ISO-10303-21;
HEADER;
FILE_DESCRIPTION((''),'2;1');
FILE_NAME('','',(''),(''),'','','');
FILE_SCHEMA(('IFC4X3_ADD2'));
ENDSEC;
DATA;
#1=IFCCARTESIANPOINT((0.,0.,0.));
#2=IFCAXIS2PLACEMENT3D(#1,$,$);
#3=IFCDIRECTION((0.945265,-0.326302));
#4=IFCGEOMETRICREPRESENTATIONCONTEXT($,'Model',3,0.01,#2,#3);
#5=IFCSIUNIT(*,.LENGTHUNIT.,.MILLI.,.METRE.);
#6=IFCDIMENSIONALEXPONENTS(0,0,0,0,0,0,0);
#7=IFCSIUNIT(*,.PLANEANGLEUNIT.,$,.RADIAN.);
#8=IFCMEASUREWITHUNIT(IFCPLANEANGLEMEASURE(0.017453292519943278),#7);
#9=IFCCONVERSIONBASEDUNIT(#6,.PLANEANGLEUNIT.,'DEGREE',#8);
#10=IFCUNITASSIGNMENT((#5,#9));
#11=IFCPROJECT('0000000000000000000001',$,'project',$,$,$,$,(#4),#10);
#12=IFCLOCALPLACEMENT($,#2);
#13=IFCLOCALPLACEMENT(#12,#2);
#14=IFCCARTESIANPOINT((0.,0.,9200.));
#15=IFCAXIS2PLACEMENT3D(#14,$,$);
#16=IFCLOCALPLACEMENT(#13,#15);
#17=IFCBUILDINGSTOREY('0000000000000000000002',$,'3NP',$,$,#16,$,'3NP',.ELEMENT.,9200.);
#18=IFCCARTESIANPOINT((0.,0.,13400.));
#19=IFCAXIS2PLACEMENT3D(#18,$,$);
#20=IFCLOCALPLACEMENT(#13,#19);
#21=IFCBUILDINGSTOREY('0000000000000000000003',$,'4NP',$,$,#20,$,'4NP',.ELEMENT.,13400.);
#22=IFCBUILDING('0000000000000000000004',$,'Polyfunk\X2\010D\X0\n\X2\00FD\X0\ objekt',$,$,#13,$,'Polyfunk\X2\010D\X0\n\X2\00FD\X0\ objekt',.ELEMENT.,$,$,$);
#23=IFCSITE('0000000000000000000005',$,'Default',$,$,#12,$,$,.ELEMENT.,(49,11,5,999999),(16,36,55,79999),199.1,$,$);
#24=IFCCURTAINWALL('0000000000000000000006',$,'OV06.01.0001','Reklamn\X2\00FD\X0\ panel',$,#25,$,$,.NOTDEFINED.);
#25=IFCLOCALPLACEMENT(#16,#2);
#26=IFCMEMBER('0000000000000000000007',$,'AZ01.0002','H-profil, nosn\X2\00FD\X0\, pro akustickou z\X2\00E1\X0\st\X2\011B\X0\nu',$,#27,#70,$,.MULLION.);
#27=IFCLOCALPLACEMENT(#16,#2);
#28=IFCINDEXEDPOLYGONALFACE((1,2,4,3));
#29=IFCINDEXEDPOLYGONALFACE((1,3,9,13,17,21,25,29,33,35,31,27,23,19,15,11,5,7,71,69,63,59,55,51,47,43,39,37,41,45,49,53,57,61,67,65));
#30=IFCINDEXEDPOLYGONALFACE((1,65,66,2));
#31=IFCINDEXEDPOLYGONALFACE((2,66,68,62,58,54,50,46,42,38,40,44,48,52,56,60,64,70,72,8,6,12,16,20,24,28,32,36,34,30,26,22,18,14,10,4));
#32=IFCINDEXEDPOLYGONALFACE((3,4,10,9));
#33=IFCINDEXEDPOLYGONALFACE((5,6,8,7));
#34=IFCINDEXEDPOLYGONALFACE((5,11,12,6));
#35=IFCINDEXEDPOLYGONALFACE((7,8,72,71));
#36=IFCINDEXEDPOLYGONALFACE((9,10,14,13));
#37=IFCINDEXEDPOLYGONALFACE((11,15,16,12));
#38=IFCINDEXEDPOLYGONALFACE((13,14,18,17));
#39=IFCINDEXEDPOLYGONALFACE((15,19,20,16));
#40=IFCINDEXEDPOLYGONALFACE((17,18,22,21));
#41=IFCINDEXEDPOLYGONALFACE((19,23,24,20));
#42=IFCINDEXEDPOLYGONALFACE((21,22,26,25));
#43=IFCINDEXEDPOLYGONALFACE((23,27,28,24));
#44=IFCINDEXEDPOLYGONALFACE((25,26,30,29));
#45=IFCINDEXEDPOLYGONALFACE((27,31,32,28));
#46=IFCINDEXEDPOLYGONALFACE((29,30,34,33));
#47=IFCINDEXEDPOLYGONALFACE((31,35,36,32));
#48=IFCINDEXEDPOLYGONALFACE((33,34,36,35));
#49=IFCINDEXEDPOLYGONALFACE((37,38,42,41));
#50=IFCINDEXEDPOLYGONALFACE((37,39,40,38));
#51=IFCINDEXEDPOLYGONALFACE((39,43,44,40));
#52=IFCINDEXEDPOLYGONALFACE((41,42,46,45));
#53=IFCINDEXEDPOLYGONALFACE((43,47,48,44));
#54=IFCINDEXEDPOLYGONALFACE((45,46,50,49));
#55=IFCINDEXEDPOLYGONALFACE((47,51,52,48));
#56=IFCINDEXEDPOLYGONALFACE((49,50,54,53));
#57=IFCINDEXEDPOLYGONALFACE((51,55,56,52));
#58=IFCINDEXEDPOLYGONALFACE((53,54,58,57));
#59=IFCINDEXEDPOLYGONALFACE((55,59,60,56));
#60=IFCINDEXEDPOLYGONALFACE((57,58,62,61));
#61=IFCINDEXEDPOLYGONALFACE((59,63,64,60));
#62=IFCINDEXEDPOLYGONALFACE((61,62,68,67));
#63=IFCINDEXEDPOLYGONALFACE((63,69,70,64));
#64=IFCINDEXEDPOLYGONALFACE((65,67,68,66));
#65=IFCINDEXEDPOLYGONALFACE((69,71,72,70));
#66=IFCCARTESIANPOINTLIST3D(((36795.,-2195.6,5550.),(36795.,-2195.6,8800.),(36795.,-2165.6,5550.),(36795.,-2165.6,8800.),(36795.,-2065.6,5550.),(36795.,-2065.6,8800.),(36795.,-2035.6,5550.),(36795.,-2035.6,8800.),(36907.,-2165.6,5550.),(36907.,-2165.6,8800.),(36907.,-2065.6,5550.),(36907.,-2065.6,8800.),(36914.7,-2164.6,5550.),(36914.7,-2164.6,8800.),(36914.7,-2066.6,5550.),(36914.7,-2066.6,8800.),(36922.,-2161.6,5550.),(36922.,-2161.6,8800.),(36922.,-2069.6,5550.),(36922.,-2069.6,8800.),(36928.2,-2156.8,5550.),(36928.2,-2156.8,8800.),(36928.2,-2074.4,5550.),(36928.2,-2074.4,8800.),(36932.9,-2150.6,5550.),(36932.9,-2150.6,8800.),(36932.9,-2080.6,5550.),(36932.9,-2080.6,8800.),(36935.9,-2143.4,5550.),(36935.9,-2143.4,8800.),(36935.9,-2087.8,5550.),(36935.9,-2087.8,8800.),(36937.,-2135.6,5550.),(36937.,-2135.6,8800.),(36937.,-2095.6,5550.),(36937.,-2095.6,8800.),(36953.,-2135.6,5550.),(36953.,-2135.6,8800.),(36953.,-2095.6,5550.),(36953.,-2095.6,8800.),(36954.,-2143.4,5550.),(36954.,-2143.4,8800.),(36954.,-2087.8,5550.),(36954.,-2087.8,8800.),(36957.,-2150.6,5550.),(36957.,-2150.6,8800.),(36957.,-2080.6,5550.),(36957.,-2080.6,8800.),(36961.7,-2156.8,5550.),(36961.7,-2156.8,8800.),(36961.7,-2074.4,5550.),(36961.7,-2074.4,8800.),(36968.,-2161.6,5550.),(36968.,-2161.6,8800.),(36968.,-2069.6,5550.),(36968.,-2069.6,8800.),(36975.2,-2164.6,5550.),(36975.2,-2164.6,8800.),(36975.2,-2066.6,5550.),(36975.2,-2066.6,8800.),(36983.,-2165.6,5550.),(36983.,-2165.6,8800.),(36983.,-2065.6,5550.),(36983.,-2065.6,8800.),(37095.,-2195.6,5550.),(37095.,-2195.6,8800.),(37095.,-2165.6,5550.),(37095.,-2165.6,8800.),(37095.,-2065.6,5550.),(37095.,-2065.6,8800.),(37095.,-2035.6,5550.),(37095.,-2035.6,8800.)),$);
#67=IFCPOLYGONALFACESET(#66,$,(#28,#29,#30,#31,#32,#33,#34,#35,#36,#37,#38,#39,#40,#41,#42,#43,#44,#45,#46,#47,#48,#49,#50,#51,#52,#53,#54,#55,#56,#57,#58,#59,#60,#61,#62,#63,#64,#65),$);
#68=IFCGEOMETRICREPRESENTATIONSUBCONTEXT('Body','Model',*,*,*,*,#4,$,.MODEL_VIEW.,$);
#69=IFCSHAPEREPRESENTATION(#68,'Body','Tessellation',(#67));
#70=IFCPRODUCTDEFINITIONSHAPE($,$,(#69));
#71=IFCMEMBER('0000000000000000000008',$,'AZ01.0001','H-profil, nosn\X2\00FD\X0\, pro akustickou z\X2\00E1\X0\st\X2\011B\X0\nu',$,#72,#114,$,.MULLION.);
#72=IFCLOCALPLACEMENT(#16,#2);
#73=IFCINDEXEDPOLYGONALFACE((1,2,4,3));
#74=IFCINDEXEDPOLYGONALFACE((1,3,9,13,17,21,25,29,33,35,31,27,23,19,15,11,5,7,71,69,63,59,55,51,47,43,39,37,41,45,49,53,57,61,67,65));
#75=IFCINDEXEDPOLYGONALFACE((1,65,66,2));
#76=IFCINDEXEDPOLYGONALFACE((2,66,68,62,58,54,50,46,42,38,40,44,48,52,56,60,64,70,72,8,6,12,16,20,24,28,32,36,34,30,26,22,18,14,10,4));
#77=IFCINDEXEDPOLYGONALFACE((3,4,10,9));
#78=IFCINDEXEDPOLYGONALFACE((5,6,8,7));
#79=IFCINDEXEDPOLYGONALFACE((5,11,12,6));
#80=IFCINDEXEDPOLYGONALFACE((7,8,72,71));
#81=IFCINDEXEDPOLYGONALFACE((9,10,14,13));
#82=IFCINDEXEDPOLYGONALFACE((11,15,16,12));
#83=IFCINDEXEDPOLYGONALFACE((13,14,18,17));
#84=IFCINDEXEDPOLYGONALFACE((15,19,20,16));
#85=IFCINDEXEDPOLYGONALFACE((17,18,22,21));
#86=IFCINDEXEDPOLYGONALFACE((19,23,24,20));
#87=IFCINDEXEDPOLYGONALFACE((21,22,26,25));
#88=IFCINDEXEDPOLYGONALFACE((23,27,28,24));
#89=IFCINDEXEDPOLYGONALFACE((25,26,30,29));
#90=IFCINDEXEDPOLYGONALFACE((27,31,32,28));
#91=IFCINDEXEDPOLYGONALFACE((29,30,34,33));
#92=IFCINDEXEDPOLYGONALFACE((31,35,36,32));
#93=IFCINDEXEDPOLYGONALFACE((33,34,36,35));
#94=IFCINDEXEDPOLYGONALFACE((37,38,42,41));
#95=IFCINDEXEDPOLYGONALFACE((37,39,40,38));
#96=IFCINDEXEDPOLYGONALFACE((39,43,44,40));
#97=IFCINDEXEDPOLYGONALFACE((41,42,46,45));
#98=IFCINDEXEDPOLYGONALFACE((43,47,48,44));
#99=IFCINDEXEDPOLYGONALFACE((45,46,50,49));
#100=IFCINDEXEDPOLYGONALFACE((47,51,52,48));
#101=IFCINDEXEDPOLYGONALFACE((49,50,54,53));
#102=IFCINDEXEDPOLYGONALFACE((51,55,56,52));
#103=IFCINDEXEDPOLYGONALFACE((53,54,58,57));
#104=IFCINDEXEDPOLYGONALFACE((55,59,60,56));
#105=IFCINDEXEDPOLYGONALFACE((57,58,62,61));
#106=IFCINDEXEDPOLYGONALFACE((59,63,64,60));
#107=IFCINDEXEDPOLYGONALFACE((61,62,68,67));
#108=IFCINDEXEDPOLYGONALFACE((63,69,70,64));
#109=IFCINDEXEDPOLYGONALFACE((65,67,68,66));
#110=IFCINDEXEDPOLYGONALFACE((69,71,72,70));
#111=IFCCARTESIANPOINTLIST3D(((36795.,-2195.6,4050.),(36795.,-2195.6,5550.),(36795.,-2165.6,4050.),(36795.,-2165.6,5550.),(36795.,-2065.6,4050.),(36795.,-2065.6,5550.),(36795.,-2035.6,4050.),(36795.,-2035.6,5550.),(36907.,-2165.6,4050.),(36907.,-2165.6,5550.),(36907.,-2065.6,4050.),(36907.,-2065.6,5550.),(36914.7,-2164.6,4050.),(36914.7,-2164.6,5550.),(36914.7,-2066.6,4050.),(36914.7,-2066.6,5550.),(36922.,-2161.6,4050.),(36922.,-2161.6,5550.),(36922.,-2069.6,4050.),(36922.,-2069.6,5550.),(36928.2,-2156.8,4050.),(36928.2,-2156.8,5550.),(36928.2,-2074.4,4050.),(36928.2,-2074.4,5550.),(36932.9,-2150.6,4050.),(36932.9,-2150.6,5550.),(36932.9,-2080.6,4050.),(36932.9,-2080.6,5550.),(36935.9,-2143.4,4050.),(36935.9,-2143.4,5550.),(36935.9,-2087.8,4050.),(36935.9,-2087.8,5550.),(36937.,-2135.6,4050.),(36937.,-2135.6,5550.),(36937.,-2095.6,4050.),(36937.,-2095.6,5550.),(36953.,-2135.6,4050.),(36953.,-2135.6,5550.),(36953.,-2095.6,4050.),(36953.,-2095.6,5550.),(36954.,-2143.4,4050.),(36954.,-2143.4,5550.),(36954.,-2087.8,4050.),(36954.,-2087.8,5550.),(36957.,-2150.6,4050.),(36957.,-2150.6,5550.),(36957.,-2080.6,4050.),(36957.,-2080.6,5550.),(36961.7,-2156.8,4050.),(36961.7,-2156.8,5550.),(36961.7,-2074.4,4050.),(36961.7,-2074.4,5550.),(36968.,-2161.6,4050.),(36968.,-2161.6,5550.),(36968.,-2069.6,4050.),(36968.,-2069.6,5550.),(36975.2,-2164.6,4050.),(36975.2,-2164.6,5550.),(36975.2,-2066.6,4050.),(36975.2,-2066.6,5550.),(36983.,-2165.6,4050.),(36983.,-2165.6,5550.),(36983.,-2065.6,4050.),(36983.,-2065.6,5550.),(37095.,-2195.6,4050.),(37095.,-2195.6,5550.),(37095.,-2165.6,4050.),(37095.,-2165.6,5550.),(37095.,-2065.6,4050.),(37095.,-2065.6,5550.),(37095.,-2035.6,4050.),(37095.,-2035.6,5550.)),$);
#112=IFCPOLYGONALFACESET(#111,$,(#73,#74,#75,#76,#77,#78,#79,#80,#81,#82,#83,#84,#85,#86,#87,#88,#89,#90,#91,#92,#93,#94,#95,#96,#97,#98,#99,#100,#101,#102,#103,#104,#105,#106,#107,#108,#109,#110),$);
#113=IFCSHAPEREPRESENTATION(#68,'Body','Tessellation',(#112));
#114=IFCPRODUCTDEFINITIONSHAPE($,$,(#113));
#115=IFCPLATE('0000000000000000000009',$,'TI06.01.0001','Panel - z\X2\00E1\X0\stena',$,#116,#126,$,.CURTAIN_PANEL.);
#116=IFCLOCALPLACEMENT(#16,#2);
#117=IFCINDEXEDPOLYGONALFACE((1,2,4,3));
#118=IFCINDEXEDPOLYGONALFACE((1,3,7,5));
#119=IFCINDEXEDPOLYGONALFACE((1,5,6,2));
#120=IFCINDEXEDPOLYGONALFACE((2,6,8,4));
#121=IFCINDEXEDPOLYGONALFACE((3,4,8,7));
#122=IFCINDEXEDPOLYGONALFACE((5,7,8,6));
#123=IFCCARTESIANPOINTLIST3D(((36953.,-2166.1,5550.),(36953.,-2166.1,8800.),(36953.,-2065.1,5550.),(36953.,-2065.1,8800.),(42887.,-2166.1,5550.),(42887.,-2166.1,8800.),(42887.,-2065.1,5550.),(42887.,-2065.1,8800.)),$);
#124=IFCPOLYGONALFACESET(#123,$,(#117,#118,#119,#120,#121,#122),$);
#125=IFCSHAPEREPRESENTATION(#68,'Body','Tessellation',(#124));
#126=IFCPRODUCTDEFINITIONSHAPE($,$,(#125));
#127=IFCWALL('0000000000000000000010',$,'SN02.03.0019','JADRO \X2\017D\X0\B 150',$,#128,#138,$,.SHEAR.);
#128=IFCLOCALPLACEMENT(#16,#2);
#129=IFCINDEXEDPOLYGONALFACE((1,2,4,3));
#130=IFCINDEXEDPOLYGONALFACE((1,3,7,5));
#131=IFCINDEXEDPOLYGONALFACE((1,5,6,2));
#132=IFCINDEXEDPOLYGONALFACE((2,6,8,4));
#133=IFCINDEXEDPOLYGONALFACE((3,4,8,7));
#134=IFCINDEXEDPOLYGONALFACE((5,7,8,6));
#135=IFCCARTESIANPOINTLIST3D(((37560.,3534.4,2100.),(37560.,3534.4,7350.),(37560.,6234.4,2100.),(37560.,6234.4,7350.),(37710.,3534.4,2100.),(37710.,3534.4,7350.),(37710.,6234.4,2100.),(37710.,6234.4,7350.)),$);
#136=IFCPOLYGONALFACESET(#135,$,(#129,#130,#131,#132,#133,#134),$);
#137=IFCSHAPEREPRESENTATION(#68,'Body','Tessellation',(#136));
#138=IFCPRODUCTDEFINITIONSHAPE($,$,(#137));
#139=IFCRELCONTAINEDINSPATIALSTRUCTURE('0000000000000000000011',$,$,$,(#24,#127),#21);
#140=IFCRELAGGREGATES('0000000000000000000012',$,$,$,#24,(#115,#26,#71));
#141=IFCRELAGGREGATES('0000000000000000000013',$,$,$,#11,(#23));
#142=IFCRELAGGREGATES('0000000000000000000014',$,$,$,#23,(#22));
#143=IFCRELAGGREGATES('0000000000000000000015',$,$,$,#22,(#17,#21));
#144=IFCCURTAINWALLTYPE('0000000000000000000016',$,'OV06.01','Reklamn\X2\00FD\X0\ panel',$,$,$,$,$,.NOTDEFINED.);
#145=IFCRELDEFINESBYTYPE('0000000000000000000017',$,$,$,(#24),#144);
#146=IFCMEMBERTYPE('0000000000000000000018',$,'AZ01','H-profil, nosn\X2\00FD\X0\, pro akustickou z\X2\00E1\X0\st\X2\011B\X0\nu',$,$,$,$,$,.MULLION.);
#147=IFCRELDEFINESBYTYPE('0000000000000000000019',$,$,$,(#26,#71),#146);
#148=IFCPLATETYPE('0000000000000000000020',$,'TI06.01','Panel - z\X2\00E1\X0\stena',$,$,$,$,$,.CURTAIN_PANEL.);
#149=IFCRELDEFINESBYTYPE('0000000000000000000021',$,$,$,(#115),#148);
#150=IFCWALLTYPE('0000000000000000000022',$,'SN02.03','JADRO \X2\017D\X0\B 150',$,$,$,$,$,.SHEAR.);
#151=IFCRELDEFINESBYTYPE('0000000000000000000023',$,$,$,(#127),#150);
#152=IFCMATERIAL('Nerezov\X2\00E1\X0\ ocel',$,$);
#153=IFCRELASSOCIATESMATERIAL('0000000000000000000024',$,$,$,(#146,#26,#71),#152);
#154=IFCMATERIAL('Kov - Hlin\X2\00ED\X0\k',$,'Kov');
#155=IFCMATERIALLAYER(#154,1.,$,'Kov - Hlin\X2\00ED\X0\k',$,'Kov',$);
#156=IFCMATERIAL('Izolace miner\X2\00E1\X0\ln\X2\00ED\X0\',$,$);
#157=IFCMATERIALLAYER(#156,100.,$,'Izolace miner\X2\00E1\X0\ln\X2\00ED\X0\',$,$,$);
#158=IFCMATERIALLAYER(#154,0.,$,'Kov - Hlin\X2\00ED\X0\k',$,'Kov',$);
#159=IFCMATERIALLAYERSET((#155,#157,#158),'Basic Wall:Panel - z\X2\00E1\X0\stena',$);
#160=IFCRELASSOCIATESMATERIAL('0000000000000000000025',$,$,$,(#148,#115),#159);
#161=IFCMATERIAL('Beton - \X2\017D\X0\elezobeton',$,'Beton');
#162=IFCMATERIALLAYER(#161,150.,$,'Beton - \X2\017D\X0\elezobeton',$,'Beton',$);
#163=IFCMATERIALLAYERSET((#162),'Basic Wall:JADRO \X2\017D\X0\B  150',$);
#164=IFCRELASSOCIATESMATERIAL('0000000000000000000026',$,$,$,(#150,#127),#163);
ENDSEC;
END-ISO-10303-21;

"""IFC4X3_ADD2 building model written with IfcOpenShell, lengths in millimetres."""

from ifc_helpers import new_model, entity, si_unit, converted_unit, direction, frame, frame_2d, origin, place, context, subcontext, project, spatial, polyline, circle_curve, parameter, trimmed, segment, composite_curve, rectangle, outline, extrude, source, transform, mapped, material, layer, layer_set, layer_usage, material_profile, profile_set, profile_usage, type_object, type_shapes, element, aggregate, save


model = new_model("IFC4X3_ADD2")

# Units and contexts
model_context = context("Model", 3, precision=0.01, world=origin(), true_north=direction((0.945265, -0.326302)))
body_context = subcontext(model_context, "Body", "Model", "MODEL_VIEW")
ifc_project = project(units=[si_unit("LENGTHUNIT", "METRE", prefix="MILLI"), converted_unit("PLANEANGLEUNIT", "DEGREE", entity("IfcPlaneAngleMeasure", 0.017453292519943278), si_unit("PLANEANGLEUNIT", "RADIAN"), dimensions=[0, 0, 0, 0, 0, 0, 0])], contexts=[model_context])

# Site, building, storey
site_placement = place(None, origin())
site = spatial("IfcSite", under=ifc_project, at=site_placement, Name="Default", CompositionType="ELEMENT", RefLatitude=(49, 11, 5, 999999), RefLongitude=(16, 36, 55, 79999), RefElevation=199.1)
building_placement = place(site_placement, origin())
building = spatial("IfcBuilding", under=site, at=building_placement, Name="Polyfunkčný objekt", LongName="Polyfunkčný objekt", CompositionType="ELEMENT")
storey_1_placement = place(building_placement, frame((0.0, 0.0, 9200.0)))
storey_1 = spatial("IfcBuildingStorey", under=building, at=storey_1_placement, Name="3NP", LongName="3NP", CompositionType="ELEMENT", Elevation=9200.0)

# Shared definitions
storey_2_placement = place(building_placement, frame((0.0, 0.0, 13400.0)))
storey_2 = spatial("IfcBuildingStorey", under=building, at=storey_2_placement, Name="4NP", LongName="4NP", CompositionType="ELEMENT", Elevation=13400.0)

# Curtain wall, members, plate
curtain_wall_type_1 = type_object("IfcCurtainWallType", Name="OV06.01", Description="Reklamný panel", PredefinedType="NOTDEFINED")
curtain_wall_1_placement = place(storey_2_placement, frame((0.0, 0.0, -13400.0)))
curtain_wall_1 = element("IfcCurtainWall", 1, at=curtain_wall_1_placement, inside=storey_2, type_object=curtain_wall_type_1, Name="OV06.01.0001", Description="Reklamný panel", PredefinedType="NOTDEFINED")
ifc_material_1 = material(Name="Nerezová ocel")
ifc_material_profile_1 = material_profile(ifc_material_1, outline(composite_curve([segment(polyline([(50.0, -150.0), (80.0, -150.0)]), True, "CONTINUOUS"), segment(polyline([(80.0, -150.0), (80.0, 150.0)]), True, "CONTINUOUS"), segment(polyline([(80.0, 150.0), (50.0, 150.0)]), True, "CONTINUOUS"), segment(polyline([(50.0, 150.0), (50.0, 38.0)]), True, "CONTINUOUS"), segment(trimmed(circle_curve(frame_2d((20.0, 38.0), x_axis=(0.0, 1.0)), 30.0), [parameter(180.0)], [parameter(270.0)], True, "PARAMETER"), False, "CONTINUOUS"), segment(polyline([(20.0, 8.0), (-20.0, 8.0)]), True, "CONTINUOUS"), segment(trimmed(circle_curve(frame_2d((-20.0, 38.0), x_axis=(0.0, 1.0)), 30.0), [parameter(90.0)], [parameter(180.0)], True, "PARAMETER"), False, "CONTINUOUS"), segment(polyline([(-50.0, 38.0), (-50.0, 150.0)]), True, "CONTINUOUS"), segment(polyline([(-50.0, 150.0), (-80.0, 150.0)]), True, "CONTINUOUS"), segment(polyline([(-80.0, 150.0), (-80.0, -150.0)]), True, "CONTINUOUS"), segment(polyline([(-80.0, -150.0), (-50.0, -150.0)]), True, "CONTINUOUS"), segment(polyline([(-50.0, -150.0), (-50.0, -38.0)]), True, "CONTINUOUS"), segment(trimmed(circle_curve(frame_2d((-20.0, -38.0), x_axis=(0.0, 1.0)), 30.0), [parameter(0.0)], [parameter(90.0)], True, "PARAMETER"), False, "CONTINUOUS"), segment(polyline([(-20.0, -8.0), (20.0, -8.0)]), True, "CONTINUOUS"), segment(trimmed(circle_curve(frame_2d((20.0, -38.0), x_axis=(0.0, 1.0)), 30.0), [parameter(270.0)], [parameter(0.0)], True, "PARAMETER"), False, "CONTINUOUS"), segment(polyline([(50.0, -38.0), (50.0, -150.0)]), True, "CONTINUOUS")], self_intersect=False)), Name="Profil zástena")
ifc_profile_set_1 = profile_set([ifc_material_profile_1], Name="Profil zástena")
ifc_profile_usage_1 = profile_usage(ifc_profile_set_1)
member_type_1 = type_object("IfcMemberType", Name="AZ01", Description="H-profil, nosný, pro akustickou zástěnu", PredefinedType="MULLION", material=ifc_profile_set_1)
shared_shape_1 = source(origin(), body_context, "Body", "SweptSolid", [
    extrude(outline(composite_curve([segment(polyline([(50.0, -150.0), (80.0, -150.0)]), True, "CONTINUOUS"), segment(polyline([(80.0, -150.0), (80.0, 150.0)]), True, "CONTINUOUS"), segment(polyline([(80.0, 150.0), (50.0, 150.0)]), True, "CONTINUOUS"), segment(polyline([(50.0, 150.0), (50.0, 38.0)]), True, "CONTINUOUS"), segment(trimmed(circle_curve(frame_2d((20.0, 38.0), x_axis=(0.0, 1.0)), 30.0), [parameter(180.0)], [parameter(270.0)], True, "PARAMETER"), False, "CONTINUOUS"), segment(polyline([(20.0, 8.0), (-20.0, 8.0)]), True, "CONTINUOUS"), segment(trimmed(circle_curve(frame_2d((-20.0, 38.0), x_axis=(0.0, 1.0)), 30.0), [parameter(90.0)], [parameter(180.0)], True, "PARAMETER"), False, "CONTINUOUS"), segment(polyline([(-50.0, 38.0), (-50.0, 150.0)]), True, "CONTINUOUS"), segment(polyline([(-50.0, 150.0), (-80.0, 150.0)]), True, "CONTINUOUS"), segment(polyline([(-80.0, 150.0), (-80.0, -150.0)]), True, "CONTINUOUS"), segment(polyline([(-80.0, -150.0), (-50.0, -150.0)]), True, "CONTINUOUS"), segment(polyline([(-50.0, -150.0), (-50.0, -38.0)]), True, "CONTINUOUS"), segment(trimmed(circle_curve(frame_2d((-20.0, -38.0), x_axis=(0.0, 1.0)), 30.0), [parameter(0.0)], [parameter(90.0)], True, "PARAMETER"), False, "CONTINUOUS"), segment(polyline([(-20.0, -8.0), (20.0, -8.0)]), True, "CONTINUOUS"), segment(trimmed(circle_curve(frame_2d((20.0, -38.0), x_axis=(0.0, 1.0)), 30.0), [parameter(270.0)], [parameter(0.0)], True, "PARAMETER"), False, "CONTINUOUS"), segment(polyline([(50.0, -38.0), (50.0, -150.0)]), True, "CONTINUOUS")], self_intersect=False)), frame((-150.0, 0.0, -3250.0), z_axis=(0.0, 0.0, 1.0), x_axis=(0.0, 1.0, 0.0)), (0.0, 0.0, 1.0), 3250.0),
])
member_1_placement = place(curtain_wall_1_placement, frame((36795.0, -2115.6, 18000.0), z_axis=(0.0, 0.0, 1.0), x_axis=(-1.0, 0.0, 0.0)))
member_1 = element("IfcMember", 2, at=member_1_placement, type_object=member_type_1, material=ifc_profile_usage_1, Name="AZ01.0002", Description="H-profil, nosný, pro akustickou zástěnu", PredefinedType="MULLION", context=body_context, shape_type="MappedRepresentation", body=[
    mapped(shared_shape_1, transform((0.0, 0.0, 0.0), scale=1.0)),
])
shared_shape_2 = source(origin(), body_context, "Body", "SweptSolid", [
    extrude(outline(composite_curve([segment(polyline([(50.0, -150.0), (80.0, -150.0)]), True, "CONTINUOUS"), segment(polyline([(80.0, -150.0), (80.0, 150.0)]), True, "CONTINUOUS"), segment(polyline([(80.0, 150.0), (50.0, 150.0)]), True, "CONTINUOUS"), segment(polyline([(50.0, 150.0), (50.0, 38.0)]), True, "CONTINUOUS"), segment(trimmed(circle_curve(frame_2d((20.0, 38.0), x_axis=(0.0, 1.0)), 30.0), [parameter(180.0)], [parameter(270.0)], True, "PARAMETER"), False, "CONTINUOUS"), segment(polyline([(20.0, 8.0), (-20.0, 8.0)]), True, "CONTINUOUS"), segment(trimmed(circle_curve(frame_2d((-20.0, 38.0), x_axis=(0.0, 1.0)), 30.0), [parameter(90.0)], [parameter(180.0)], True, "PARAMETER"), False, "CONTINUOUS"), segment(polyline([(-50.0, 38.0), (-50.0, 150.0)]), True, "CONTINUOUS"), segment(polyline([(-50.0, 150.0), (-80.0, 150.0)]), True, "CONTINUOUS"), segment(polyline([(-80.0, 150.0), (-80.0, -150.0)]), True, "CONTINUOUS"), segment(polyline([(-80.0, -150.0), (-50.0, -150.0)]), True, "CONTINUOUS"), segment(polyline([(-50.0, -150.0), (-50.0, -38.0)]), True, "CONTINUOUS"), segment(trimmed(circle_curve(frame_2d((-20.0, -38.0), x_axis=(0.0, 1.0)), 30.0), [parameter(0.0)], [parameter(90.0)], True, "PARAMETER"), False, "CONTINUOUS"), segment(polyline([(-20.0, -8.0), (20.0, -8.0)]), True, "CONTINUOUS"), segment(trimmed(circle_curve(frame_2d((20.0, -38.0), x_axis=(0.0, 1.0)), 30.0), [parameter(270.0)], [parameter(0.0)], True, "PARAMETER"), False, "CONTINUOUS"), segment(polyline([(50.0, -38.0), (50.0, -150.0)]), True, "CONTINUOUS")], self_intersect=False)), frame((-150.0, 0.0, -1500.0), z_axis=(0.0, 0.0, 1.0), x_axis=(0.0, 1.0, 0.0)), (0.0, 0.0, 1.0), 1500.0),
])
type_shapes(member_type_1, [shared_shape_1, shared_shape_2])
member_2_placement = place(curtain_wall_1_placement, frame((36795.0, -2115.6, 14750.0), z_axis=(0.0, 0.0, 1.0), x_axis=(-1.0, 0.0, 0.0)))
member_2 = element("IfcMember", 3, at=member_2_placement, type_object=member_type_1, material=ifc_profile_usage_1, Name="AZ01.0001", Description="H-profil, nosný, pro akustickou zástěnu", PredefinedType="MULLION", context=body_context, shape_type="MappedRepresentation", body=[
    mapped(shared_shape_2, transform((0.0, 0.0, 0.0), scale=1.0)),
])
ifc_material_2 = material(Name="Kov - Hliník", Category="Kov")
ifc_layer_1 = layer(ifc_material_2, 1.0, Name="Kov - Hliník", Category="Kov")
ifc_material_3 = material(Name="Izolace minerální")
ifc_layer_2 = layer(ifc_material_3, 100.0, Name="Izolace minerální")
ifc_layer_3 = layer(ifc_material_2, 0.0, Name="Kov - Hliník", Category="Kov")
ifc_layer_set_1 = layer_set([ifc_layer_1, ifc_layer_2, ifc_layer_3], Name="Basic Wall:Panel - zástena")
ifc_layer_usage = layer_usage(ifc_layer_set_1, "AXIS2", "NEGATIVE", 50.5)
plate_type = type_object("IfcPlateType", Name="TI06.01", Description="Panel - zástena", PredefinedType="CURTAIN_PANEL", material=ifc_layer_set_1)
plate_placement = place(storey_2_placement, frame((36953.0, -2115.6, 1350.0)))
plate = element("IfcPlate", 4, at=plate_placement, type_object=plate_type, material=ifc_layer_usage, Name="TI06.01.0001", Description="Panel - zástena", PredefinedType="CURTAIN_PANEL", context=body_context, shape_type="SweptSolid", body=[
    extrude(rectangle(XDim=101.0, YDim=5934.0, at=frame_2d((0.0, 0.0), x_axis=(1.0, 0.0))), frame((2967.0, 0.0, 0.0), z_axis=(0.0, 0.0, 1.0), x_axis=(0.0, 1.0, 0.0)), (0.0, 0.0, 1.0), 3250.0),
])
aggregate(curtain_wall_1, [plate, member_1, member_2])

# Wall
ifc_material_4 = material(Name="Beton - Železobeton", Category="Beton")
ifc_layer_4 = layer(ifc_material_4, 150.0, Name="Beton - Železobeton", Category="Beton")
ifc_layer_set_2 = layer_set([ifc_layer_4], Name="Basic Wall:JADRO ŽB  150")
wall_type = type_object("IfcWallType", Name="SN02.03", Description="JADRO ŽB 150", PredefinedType="SHEAR", material=ifc_layer_set_2)
wall_placement = place(storey_2_placement, frame((37635.0, 6234.4, -2100.0), z_axis=(0.0, 0.0, 1.0), x_axis=(0.0, -1.0, 0.0)))
element("IfcWall", 5, at=wall_placement, inside=storey_2, type_object=wall_type, material=ifc_layer_set_2, Name="SN02.03.0019", Description="JADRO ŽB 150", PredefinedType="SHEAR", context=body_context, shape_type="SweptSolid", body=[
    extrude(rectangle(XDim=2700.0, YDim=150.0, at=frame_2d((1350.0, 0.0), x_axis=(-1.0, 0.0))), origin(), (0.0, 0.0, 1.0), 5250.0),
])

save(model, "model.ifc")
